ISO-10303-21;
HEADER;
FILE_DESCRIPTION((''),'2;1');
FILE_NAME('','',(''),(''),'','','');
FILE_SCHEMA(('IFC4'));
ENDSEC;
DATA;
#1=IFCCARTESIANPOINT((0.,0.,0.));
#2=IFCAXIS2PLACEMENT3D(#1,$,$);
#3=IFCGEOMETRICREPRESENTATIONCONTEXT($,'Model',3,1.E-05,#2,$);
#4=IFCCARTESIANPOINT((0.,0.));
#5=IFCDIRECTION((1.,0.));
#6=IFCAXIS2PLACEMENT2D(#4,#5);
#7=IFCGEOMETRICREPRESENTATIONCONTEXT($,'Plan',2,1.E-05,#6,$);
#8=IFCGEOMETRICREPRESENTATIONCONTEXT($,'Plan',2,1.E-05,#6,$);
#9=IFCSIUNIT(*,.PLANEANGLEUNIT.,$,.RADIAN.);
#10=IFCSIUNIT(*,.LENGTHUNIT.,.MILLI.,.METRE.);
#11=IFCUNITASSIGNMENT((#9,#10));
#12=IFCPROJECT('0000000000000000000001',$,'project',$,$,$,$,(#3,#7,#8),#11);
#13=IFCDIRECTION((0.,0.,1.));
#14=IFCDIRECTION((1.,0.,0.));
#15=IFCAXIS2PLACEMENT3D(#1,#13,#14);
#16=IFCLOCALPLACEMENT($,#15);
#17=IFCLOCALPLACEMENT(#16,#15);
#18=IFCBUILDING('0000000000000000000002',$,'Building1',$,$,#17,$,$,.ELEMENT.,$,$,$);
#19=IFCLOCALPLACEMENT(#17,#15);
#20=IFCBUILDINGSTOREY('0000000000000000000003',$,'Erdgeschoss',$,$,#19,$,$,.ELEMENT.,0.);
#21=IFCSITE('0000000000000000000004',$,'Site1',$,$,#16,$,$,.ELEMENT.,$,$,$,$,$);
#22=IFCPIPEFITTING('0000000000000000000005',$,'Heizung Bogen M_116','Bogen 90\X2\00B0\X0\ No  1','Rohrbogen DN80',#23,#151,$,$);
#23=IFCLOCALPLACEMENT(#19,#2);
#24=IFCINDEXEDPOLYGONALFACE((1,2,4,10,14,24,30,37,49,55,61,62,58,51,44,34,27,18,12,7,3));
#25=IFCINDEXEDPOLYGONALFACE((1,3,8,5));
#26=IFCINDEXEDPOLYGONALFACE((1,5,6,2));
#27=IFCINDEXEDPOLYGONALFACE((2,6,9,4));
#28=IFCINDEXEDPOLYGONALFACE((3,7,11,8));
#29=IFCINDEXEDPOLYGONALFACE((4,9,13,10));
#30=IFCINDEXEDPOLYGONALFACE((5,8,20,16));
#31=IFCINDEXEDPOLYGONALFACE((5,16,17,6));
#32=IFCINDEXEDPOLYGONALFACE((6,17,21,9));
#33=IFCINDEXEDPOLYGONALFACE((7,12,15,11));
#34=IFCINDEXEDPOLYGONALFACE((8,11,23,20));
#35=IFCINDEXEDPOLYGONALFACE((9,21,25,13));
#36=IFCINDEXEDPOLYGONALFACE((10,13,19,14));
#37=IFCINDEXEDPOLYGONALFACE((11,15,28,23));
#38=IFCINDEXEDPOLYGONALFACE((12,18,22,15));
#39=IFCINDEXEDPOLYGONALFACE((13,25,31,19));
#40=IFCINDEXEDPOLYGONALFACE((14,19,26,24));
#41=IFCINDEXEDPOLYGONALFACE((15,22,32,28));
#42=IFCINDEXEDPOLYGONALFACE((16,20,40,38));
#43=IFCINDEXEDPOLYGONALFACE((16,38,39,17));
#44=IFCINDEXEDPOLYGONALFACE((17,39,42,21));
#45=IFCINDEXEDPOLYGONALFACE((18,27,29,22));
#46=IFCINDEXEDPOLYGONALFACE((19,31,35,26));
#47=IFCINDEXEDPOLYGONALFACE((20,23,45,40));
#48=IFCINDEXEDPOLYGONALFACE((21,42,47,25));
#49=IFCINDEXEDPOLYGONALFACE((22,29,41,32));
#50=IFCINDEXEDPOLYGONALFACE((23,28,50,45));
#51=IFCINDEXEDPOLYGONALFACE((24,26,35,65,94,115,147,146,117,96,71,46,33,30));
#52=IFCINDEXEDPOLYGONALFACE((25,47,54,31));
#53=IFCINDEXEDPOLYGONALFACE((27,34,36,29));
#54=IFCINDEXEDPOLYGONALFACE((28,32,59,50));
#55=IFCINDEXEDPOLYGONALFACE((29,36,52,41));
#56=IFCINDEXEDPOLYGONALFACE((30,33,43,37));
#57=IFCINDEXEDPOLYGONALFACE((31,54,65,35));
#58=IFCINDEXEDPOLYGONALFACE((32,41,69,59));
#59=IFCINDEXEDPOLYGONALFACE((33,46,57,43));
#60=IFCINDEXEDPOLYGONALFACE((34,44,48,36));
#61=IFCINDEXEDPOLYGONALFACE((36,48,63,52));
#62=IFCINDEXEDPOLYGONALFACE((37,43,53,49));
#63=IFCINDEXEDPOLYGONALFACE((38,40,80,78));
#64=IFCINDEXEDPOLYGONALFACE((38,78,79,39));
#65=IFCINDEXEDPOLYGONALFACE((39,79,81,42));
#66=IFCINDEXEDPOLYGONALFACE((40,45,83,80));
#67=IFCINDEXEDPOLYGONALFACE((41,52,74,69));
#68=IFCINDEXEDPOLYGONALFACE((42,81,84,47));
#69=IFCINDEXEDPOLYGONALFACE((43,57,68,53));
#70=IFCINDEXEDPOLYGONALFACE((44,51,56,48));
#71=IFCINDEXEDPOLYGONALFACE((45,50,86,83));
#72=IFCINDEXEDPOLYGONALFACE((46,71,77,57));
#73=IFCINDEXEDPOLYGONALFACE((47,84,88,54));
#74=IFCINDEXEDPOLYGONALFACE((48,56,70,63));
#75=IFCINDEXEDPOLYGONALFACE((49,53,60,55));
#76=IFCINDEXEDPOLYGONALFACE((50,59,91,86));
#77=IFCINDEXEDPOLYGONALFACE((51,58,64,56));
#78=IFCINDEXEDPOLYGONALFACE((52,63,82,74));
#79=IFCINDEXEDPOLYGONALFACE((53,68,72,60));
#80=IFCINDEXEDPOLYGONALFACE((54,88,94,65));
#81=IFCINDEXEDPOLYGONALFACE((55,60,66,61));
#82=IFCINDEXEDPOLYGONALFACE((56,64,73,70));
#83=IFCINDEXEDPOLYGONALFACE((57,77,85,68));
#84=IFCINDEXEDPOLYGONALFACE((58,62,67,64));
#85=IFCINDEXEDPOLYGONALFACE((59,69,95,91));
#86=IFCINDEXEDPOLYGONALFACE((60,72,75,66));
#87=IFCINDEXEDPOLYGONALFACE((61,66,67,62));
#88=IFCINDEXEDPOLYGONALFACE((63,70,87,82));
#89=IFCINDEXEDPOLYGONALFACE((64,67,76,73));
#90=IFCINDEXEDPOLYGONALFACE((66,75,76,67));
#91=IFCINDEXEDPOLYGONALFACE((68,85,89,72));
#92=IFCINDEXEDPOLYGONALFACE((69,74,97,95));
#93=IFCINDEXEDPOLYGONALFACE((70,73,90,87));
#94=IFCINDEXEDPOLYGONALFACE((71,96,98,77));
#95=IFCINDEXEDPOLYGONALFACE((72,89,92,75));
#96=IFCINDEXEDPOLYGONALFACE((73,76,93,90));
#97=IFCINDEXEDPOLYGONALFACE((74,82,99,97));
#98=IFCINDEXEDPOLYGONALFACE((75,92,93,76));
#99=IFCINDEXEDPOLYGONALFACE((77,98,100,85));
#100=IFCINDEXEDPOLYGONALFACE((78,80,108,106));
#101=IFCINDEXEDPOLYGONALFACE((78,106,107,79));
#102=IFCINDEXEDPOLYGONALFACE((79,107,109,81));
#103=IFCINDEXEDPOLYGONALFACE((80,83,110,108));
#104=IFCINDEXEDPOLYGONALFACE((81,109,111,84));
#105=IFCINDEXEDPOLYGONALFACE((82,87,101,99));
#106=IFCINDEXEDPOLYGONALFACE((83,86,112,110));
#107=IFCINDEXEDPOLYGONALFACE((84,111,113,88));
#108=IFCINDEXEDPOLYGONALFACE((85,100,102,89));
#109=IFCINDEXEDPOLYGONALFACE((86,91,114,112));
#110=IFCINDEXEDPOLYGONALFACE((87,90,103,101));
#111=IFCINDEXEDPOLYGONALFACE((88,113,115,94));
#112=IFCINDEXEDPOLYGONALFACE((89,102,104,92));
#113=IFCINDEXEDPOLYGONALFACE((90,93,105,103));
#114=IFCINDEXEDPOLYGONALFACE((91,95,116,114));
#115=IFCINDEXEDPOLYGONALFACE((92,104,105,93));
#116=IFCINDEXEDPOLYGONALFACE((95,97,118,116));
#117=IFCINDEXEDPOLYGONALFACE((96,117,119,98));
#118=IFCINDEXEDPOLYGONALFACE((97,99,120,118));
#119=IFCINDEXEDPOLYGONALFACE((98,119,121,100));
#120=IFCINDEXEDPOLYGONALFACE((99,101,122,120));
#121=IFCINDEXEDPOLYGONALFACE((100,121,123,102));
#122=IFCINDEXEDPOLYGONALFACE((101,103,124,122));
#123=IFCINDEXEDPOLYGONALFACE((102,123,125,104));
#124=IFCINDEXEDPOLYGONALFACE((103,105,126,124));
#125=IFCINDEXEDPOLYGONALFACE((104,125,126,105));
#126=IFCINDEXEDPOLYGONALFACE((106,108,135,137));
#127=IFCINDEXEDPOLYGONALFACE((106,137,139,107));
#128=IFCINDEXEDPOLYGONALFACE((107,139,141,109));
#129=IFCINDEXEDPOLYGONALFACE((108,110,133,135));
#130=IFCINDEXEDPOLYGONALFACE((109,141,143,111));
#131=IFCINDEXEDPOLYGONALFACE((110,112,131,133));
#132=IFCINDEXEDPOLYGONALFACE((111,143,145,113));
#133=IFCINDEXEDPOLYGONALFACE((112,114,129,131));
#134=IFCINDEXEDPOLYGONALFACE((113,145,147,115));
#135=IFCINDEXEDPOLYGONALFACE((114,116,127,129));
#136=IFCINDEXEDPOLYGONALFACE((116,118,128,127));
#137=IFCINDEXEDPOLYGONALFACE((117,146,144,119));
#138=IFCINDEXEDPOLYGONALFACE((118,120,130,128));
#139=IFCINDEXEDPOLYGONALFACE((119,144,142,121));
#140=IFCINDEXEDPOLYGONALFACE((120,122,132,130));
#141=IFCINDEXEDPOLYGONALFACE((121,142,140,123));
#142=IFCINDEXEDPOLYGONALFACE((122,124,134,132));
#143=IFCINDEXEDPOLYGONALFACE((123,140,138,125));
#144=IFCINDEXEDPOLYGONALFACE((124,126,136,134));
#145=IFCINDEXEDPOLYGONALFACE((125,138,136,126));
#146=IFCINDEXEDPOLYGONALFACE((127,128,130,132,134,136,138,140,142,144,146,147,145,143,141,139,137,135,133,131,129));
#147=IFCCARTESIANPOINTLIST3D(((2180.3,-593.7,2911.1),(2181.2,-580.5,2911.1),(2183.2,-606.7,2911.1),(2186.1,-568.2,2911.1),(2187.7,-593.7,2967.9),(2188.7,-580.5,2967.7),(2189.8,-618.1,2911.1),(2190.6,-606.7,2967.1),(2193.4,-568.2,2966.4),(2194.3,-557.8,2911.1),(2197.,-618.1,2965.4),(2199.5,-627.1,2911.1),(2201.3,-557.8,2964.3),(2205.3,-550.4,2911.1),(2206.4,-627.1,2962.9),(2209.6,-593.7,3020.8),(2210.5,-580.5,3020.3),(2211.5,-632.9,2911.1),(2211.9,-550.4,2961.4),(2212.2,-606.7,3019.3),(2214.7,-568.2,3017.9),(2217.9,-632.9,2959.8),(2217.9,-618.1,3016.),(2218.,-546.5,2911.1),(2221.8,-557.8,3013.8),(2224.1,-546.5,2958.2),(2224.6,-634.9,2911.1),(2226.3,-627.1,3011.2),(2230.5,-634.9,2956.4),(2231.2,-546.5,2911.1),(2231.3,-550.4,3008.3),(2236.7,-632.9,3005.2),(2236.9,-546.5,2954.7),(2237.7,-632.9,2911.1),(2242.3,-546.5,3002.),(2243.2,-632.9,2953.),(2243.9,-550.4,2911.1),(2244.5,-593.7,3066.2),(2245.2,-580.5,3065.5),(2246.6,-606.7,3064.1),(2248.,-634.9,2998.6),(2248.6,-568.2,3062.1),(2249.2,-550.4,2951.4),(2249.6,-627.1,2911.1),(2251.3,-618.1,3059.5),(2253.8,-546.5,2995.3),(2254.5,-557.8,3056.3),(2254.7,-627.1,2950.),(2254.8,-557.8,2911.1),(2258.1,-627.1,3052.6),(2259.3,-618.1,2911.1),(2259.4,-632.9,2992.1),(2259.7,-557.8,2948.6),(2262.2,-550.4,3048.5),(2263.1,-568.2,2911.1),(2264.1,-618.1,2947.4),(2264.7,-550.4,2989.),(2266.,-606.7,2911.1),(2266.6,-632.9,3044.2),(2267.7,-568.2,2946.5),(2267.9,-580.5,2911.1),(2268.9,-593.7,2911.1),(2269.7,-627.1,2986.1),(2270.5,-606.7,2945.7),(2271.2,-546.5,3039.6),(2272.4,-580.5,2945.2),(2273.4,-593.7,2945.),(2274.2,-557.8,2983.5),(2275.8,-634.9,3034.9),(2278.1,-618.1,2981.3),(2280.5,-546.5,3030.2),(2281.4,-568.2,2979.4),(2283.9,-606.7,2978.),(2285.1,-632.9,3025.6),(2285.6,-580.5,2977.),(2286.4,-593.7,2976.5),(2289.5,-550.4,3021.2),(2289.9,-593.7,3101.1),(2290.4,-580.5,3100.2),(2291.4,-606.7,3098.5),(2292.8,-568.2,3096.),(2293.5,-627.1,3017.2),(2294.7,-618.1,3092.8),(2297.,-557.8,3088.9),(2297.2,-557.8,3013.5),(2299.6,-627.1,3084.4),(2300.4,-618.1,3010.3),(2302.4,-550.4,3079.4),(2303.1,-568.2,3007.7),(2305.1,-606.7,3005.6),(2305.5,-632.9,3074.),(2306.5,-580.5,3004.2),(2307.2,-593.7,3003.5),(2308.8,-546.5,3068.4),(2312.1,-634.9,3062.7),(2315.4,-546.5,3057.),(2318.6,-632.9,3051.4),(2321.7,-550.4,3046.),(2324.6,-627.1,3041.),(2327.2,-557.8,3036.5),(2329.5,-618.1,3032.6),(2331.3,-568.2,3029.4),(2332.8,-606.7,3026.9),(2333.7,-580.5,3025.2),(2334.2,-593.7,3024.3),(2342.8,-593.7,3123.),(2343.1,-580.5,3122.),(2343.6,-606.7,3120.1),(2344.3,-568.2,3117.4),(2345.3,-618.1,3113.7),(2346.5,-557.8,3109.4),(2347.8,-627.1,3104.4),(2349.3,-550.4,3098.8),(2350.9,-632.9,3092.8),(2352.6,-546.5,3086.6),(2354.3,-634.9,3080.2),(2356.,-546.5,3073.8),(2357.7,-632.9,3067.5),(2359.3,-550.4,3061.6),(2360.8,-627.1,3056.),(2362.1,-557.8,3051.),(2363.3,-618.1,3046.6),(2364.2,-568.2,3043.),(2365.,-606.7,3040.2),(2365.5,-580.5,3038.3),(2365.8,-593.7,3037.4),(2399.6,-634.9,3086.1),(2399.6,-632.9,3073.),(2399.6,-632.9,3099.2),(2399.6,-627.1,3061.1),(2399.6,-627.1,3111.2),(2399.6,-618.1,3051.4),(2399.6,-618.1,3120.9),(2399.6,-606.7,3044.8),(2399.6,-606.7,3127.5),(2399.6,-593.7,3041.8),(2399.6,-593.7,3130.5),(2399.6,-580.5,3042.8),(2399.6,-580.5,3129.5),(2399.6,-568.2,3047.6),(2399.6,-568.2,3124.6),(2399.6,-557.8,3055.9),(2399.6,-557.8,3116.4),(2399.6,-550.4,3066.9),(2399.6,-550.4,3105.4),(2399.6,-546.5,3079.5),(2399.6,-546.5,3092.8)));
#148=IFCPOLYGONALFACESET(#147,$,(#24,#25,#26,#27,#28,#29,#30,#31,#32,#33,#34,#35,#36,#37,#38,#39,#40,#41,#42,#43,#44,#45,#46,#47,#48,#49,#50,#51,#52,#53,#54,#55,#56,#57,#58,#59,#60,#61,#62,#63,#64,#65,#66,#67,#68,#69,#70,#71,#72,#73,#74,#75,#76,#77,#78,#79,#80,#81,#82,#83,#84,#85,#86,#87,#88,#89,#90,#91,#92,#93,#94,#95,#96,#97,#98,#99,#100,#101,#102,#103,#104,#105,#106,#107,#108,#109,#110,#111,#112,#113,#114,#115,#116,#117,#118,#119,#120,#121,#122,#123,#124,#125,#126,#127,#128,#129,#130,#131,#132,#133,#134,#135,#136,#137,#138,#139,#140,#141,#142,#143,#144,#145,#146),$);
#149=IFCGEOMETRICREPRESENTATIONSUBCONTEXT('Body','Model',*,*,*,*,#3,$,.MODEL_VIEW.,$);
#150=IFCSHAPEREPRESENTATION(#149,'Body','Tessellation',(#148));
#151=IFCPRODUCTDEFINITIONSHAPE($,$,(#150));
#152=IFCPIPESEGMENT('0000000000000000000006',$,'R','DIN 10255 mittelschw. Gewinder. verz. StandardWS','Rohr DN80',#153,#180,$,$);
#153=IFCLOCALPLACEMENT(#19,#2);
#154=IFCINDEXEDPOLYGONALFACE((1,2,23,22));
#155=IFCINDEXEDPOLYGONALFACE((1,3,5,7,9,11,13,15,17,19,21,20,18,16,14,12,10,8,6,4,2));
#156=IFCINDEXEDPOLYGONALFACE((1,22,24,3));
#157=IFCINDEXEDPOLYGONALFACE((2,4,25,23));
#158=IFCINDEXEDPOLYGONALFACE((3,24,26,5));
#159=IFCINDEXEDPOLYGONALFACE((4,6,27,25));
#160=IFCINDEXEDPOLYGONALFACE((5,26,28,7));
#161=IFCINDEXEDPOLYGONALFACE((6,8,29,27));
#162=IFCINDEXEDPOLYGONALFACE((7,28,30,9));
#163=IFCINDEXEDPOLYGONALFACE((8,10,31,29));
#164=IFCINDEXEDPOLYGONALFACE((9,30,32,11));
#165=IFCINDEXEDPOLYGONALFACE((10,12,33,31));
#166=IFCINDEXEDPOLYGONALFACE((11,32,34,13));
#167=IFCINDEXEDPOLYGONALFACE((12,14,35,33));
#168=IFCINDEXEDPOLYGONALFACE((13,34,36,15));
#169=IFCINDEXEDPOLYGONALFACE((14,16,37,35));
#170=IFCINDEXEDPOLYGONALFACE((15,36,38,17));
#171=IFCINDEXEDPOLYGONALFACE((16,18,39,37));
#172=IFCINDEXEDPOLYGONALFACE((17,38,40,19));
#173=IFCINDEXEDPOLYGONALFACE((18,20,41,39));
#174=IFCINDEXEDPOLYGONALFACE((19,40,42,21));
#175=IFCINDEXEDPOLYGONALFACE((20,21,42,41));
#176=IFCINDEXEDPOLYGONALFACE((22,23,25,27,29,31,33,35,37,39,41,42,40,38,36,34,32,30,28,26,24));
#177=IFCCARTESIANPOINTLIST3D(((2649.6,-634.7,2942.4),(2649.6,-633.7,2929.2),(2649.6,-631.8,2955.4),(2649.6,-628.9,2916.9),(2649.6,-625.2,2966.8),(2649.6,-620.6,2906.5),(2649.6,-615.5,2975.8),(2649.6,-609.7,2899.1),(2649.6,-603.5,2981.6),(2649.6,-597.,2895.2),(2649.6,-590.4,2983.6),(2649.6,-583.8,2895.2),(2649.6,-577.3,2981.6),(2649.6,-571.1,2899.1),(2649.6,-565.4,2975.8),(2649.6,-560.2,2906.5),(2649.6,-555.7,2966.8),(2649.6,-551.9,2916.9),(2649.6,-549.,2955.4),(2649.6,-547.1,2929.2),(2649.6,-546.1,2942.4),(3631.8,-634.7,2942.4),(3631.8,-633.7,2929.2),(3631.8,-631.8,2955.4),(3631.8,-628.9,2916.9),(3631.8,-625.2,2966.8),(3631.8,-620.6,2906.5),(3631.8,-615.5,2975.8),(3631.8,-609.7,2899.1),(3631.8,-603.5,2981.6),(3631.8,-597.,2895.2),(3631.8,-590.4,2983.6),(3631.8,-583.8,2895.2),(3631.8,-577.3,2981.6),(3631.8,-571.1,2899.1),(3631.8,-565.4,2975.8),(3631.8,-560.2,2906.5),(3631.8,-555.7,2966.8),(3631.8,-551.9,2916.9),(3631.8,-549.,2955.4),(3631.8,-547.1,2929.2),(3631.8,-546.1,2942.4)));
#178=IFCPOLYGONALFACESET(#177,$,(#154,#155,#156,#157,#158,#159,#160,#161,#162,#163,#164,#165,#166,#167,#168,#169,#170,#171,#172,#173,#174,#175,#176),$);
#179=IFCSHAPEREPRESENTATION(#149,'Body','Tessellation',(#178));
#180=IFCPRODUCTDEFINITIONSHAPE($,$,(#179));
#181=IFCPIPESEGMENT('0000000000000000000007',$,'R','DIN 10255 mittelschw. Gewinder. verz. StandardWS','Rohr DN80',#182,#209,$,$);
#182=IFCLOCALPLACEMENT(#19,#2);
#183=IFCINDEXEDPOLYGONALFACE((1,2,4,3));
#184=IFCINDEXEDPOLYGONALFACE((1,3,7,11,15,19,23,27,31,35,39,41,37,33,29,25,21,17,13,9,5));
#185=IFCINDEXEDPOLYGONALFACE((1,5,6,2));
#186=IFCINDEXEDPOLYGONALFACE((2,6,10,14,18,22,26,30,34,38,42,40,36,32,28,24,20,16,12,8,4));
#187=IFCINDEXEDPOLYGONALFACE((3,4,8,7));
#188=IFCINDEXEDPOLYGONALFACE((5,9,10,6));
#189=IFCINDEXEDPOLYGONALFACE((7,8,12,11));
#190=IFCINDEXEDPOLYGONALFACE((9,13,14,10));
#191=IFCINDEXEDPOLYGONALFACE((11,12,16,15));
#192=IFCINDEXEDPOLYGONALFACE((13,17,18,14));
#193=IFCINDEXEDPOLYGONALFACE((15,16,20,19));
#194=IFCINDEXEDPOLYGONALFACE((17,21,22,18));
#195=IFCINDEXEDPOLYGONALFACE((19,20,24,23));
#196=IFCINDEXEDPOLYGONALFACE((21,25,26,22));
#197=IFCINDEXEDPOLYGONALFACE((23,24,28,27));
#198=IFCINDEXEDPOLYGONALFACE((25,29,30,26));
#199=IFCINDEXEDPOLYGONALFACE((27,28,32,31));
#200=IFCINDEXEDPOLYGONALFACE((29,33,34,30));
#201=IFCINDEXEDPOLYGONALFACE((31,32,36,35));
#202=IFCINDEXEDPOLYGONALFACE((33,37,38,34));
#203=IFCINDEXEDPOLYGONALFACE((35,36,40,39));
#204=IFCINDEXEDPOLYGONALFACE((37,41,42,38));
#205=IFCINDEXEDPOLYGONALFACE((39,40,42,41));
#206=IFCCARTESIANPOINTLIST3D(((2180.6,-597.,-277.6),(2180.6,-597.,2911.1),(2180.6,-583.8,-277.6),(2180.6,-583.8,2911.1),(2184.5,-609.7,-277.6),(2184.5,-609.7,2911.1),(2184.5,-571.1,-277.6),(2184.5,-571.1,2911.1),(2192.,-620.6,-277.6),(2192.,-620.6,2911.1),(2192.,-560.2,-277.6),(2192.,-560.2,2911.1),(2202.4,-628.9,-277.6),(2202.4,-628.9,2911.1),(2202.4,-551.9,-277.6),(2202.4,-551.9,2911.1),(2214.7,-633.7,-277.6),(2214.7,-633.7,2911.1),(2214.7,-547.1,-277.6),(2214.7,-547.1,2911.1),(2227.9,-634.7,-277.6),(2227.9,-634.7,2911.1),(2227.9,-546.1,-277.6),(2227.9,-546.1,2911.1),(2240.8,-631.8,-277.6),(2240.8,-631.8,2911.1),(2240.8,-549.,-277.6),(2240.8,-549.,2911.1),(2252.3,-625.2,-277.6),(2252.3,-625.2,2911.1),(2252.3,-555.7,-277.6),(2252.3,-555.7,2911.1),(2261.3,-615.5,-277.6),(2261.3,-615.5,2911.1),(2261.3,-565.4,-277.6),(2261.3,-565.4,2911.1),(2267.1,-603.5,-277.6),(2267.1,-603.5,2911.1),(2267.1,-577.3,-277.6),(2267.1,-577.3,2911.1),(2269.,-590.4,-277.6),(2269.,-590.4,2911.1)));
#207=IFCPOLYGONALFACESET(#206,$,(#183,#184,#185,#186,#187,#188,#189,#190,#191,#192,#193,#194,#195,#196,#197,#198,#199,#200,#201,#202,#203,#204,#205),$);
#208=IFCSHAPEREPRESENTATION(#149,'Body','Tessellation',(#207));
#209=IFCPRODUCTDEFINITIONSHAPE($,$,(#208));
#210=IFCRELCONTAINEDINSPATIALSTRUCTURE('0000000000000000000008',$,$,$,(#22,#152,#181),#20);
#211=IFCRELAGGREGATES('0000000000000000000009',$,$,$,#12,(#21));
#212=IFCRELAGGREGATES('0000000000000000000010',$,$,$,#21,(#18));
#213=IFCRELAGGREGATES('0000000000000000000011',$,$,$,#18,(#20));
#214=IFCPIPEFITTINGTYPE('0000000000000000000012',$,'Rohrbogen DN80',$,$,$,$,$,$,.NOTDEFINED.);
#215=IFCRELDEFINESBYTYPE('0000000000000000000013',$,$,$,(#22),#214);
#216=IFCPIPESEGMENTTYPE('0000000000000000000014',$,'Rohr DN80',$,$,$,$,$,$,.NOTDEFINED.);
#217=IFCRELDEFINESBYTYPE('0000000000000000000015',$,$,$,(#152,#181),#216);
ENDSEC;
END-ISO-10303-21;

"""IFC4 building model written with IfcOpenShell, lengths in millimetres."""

from ifc_helpers import new_model, entity, si_unit, frame, origin, origin_with_axes, origin_2d_with_axis, place, context, subcontext, project, spatial, circle, extrude, source, transform, mapped, type_object, element, save


model = new_model("IFC4")

# Units and contexts
model_context = context("Model", 3, precision=1e-05, world=origin())
plan_context_1 = context("Plan", 2, precision=1e-05, world=origin_2d_with_axis())
plan_context_2 = context("Plan", 2, precision=1e-05, world=origin_2d_with_axis())
body_context = subcontext(model_context, "Body", "Model", "MODEL_VIEW")
ifc_project = project(units=[si_unit("PLANEANGLEUNIT", "RADIAN"), si_unit("LENGTHUNIT", "METRE", prefix="MILLI")], contexts=[model_context, plan_context_1, plan_context_2])

# Site, building, storey
site_placement = place(None, origin_with_axes())
site = spatial("IfcSite", under=ifc_project, at=site_placement, Name="Site1", CompositionType="ELEMENT")
building_placement = place(site_placement, origin_with_axes())
building = spatial("IfcBuilding", under=site, at=building_placement, Name="Building1", CompositionType="ELEMENT")
storey_placement = place(building_placement, origin_with_axes())
storey = spatial("IfcBuildingStorey", under=building, at=storey_placement, Name="Erdgeschoss", CompositionType="ELEMENT", Elevation=0.0)

# Pipe fitting
pipe_fitting_type_1 = type_object("IfcPipeFittingType", Name="Rohrbogen DN80", PredefinedType="NOTDEFINED")
shared_shape_1 = source(origin_with_axes(), body_context, "Body", "SolidModel", [
    entity("IfcRevolvedAreaSolid", entity("IfcCircleProfileDef", "AREA", None, entity("IfcAxis2Placement2D", entity("IfcCartesianPoint", [0.0, 0.0]), entity("IfcDirection", [1.0, 0.0])), 44.5), entity("IfcAxis2Placement3D", entity("IfcCartesianPoint", [109.7, -65.3, 0.0]), entity("IfcDirection", [-1.0, 0.0, 0.0]), entity("IfcDirection", [0.0, 0.0, 1.0])), entity("IfcAxis1Placement", entity("IfcCartesianPoint", [0.0, 175.0, 0.0]), entity("IfcDirection", [-1.0, 0.0, 0.0])), 1.570796),
])
pipe_fitting_1_placement = place(storey_placement, frame((2289.9, -590.4, 3020.9), z_axis=(0.0, 0.0, 1.0), x_axis=(1.0, 0.0, 0.0)))
element("IfcPipeFitting", 1, at=pipe_fitting_1_placement, inside=storey, type_object=pipe_fitting_type_1, Name="Heizung Bogen M_116", Description="Bogen 90° No  1", ObjectType="Rohrbogen DN80", context=body_context, shape_type="MappedRepresentation", body=[
    mapped(shared_shape_1, transform((0.0, 0.0, 0.0), x_axis=(0.0, 0.0, -1.0), y_axis=(1.0, 0.0, 0.0), z_axis=(0.0, -1.0, 0.0), scale=1.0)),
])

# Pipe segments
pipe_segment_type_1 = type_object("IfcPipeSegmentType", Name="Rohr DN80", PredefinedType="NOTDEFINED")
pipe_segment_1_placement = place(storey_placement, frame((3140.7, -590.3, 2939.1), z_axis=(0.0, 0.0, 1.0), x_axis=(1.0, 0.0, 0.0)))
element("IfcPipeSegment", 2, at=pipe_segment_1_placement, inside=storey, type_object=pipe_segment_type_1, Name="R", Description="DIN 10255 mittelschw. Gewinder. verz. StandardWS", ObjectType="Rohr DN80", context=body_context, shape_type="SolidModel", body=[
    extrude(circle(Radius=44.5, at=origin_2d_with_axis()), frame((-491.1, -0.2, 0.0), z_axis=(1.0, 0.0, 0.0), x_axis=(0.0, 0.0, 1.0)), (0.0, 0.0, 1.0), 982.2),
])
pipe_segment_2_placement = place(storey_placement, frame((2224.6, -590.6, 1316.8), z_axis=(0.0, 0.0, 1.0), x_axis=(1.0, 0.0, 0.0)))
element("IfcPipeSegment", 3, at=pipe_segment_2_placement, inside=storey, type_object=pipe_segment_type_1, Name="R", Description="DIN 10255 mittelschw. Gewinder. verz. StandardWS", ObjectType="Rohr DN80", context=body_context, shape_type="SolidModel", body=[
    extrude(circle(Radius=44.5, at=origin_2d_with_axis()), frame((0.0, 0.1, -1594.4), z_axis=(0.0, 0.0, 1.0), x_axis=(1.0, 0.0, 0.0)), (0.0, 0.0, 1.0), 3188.8),
])

save(model, "model.ifc")
